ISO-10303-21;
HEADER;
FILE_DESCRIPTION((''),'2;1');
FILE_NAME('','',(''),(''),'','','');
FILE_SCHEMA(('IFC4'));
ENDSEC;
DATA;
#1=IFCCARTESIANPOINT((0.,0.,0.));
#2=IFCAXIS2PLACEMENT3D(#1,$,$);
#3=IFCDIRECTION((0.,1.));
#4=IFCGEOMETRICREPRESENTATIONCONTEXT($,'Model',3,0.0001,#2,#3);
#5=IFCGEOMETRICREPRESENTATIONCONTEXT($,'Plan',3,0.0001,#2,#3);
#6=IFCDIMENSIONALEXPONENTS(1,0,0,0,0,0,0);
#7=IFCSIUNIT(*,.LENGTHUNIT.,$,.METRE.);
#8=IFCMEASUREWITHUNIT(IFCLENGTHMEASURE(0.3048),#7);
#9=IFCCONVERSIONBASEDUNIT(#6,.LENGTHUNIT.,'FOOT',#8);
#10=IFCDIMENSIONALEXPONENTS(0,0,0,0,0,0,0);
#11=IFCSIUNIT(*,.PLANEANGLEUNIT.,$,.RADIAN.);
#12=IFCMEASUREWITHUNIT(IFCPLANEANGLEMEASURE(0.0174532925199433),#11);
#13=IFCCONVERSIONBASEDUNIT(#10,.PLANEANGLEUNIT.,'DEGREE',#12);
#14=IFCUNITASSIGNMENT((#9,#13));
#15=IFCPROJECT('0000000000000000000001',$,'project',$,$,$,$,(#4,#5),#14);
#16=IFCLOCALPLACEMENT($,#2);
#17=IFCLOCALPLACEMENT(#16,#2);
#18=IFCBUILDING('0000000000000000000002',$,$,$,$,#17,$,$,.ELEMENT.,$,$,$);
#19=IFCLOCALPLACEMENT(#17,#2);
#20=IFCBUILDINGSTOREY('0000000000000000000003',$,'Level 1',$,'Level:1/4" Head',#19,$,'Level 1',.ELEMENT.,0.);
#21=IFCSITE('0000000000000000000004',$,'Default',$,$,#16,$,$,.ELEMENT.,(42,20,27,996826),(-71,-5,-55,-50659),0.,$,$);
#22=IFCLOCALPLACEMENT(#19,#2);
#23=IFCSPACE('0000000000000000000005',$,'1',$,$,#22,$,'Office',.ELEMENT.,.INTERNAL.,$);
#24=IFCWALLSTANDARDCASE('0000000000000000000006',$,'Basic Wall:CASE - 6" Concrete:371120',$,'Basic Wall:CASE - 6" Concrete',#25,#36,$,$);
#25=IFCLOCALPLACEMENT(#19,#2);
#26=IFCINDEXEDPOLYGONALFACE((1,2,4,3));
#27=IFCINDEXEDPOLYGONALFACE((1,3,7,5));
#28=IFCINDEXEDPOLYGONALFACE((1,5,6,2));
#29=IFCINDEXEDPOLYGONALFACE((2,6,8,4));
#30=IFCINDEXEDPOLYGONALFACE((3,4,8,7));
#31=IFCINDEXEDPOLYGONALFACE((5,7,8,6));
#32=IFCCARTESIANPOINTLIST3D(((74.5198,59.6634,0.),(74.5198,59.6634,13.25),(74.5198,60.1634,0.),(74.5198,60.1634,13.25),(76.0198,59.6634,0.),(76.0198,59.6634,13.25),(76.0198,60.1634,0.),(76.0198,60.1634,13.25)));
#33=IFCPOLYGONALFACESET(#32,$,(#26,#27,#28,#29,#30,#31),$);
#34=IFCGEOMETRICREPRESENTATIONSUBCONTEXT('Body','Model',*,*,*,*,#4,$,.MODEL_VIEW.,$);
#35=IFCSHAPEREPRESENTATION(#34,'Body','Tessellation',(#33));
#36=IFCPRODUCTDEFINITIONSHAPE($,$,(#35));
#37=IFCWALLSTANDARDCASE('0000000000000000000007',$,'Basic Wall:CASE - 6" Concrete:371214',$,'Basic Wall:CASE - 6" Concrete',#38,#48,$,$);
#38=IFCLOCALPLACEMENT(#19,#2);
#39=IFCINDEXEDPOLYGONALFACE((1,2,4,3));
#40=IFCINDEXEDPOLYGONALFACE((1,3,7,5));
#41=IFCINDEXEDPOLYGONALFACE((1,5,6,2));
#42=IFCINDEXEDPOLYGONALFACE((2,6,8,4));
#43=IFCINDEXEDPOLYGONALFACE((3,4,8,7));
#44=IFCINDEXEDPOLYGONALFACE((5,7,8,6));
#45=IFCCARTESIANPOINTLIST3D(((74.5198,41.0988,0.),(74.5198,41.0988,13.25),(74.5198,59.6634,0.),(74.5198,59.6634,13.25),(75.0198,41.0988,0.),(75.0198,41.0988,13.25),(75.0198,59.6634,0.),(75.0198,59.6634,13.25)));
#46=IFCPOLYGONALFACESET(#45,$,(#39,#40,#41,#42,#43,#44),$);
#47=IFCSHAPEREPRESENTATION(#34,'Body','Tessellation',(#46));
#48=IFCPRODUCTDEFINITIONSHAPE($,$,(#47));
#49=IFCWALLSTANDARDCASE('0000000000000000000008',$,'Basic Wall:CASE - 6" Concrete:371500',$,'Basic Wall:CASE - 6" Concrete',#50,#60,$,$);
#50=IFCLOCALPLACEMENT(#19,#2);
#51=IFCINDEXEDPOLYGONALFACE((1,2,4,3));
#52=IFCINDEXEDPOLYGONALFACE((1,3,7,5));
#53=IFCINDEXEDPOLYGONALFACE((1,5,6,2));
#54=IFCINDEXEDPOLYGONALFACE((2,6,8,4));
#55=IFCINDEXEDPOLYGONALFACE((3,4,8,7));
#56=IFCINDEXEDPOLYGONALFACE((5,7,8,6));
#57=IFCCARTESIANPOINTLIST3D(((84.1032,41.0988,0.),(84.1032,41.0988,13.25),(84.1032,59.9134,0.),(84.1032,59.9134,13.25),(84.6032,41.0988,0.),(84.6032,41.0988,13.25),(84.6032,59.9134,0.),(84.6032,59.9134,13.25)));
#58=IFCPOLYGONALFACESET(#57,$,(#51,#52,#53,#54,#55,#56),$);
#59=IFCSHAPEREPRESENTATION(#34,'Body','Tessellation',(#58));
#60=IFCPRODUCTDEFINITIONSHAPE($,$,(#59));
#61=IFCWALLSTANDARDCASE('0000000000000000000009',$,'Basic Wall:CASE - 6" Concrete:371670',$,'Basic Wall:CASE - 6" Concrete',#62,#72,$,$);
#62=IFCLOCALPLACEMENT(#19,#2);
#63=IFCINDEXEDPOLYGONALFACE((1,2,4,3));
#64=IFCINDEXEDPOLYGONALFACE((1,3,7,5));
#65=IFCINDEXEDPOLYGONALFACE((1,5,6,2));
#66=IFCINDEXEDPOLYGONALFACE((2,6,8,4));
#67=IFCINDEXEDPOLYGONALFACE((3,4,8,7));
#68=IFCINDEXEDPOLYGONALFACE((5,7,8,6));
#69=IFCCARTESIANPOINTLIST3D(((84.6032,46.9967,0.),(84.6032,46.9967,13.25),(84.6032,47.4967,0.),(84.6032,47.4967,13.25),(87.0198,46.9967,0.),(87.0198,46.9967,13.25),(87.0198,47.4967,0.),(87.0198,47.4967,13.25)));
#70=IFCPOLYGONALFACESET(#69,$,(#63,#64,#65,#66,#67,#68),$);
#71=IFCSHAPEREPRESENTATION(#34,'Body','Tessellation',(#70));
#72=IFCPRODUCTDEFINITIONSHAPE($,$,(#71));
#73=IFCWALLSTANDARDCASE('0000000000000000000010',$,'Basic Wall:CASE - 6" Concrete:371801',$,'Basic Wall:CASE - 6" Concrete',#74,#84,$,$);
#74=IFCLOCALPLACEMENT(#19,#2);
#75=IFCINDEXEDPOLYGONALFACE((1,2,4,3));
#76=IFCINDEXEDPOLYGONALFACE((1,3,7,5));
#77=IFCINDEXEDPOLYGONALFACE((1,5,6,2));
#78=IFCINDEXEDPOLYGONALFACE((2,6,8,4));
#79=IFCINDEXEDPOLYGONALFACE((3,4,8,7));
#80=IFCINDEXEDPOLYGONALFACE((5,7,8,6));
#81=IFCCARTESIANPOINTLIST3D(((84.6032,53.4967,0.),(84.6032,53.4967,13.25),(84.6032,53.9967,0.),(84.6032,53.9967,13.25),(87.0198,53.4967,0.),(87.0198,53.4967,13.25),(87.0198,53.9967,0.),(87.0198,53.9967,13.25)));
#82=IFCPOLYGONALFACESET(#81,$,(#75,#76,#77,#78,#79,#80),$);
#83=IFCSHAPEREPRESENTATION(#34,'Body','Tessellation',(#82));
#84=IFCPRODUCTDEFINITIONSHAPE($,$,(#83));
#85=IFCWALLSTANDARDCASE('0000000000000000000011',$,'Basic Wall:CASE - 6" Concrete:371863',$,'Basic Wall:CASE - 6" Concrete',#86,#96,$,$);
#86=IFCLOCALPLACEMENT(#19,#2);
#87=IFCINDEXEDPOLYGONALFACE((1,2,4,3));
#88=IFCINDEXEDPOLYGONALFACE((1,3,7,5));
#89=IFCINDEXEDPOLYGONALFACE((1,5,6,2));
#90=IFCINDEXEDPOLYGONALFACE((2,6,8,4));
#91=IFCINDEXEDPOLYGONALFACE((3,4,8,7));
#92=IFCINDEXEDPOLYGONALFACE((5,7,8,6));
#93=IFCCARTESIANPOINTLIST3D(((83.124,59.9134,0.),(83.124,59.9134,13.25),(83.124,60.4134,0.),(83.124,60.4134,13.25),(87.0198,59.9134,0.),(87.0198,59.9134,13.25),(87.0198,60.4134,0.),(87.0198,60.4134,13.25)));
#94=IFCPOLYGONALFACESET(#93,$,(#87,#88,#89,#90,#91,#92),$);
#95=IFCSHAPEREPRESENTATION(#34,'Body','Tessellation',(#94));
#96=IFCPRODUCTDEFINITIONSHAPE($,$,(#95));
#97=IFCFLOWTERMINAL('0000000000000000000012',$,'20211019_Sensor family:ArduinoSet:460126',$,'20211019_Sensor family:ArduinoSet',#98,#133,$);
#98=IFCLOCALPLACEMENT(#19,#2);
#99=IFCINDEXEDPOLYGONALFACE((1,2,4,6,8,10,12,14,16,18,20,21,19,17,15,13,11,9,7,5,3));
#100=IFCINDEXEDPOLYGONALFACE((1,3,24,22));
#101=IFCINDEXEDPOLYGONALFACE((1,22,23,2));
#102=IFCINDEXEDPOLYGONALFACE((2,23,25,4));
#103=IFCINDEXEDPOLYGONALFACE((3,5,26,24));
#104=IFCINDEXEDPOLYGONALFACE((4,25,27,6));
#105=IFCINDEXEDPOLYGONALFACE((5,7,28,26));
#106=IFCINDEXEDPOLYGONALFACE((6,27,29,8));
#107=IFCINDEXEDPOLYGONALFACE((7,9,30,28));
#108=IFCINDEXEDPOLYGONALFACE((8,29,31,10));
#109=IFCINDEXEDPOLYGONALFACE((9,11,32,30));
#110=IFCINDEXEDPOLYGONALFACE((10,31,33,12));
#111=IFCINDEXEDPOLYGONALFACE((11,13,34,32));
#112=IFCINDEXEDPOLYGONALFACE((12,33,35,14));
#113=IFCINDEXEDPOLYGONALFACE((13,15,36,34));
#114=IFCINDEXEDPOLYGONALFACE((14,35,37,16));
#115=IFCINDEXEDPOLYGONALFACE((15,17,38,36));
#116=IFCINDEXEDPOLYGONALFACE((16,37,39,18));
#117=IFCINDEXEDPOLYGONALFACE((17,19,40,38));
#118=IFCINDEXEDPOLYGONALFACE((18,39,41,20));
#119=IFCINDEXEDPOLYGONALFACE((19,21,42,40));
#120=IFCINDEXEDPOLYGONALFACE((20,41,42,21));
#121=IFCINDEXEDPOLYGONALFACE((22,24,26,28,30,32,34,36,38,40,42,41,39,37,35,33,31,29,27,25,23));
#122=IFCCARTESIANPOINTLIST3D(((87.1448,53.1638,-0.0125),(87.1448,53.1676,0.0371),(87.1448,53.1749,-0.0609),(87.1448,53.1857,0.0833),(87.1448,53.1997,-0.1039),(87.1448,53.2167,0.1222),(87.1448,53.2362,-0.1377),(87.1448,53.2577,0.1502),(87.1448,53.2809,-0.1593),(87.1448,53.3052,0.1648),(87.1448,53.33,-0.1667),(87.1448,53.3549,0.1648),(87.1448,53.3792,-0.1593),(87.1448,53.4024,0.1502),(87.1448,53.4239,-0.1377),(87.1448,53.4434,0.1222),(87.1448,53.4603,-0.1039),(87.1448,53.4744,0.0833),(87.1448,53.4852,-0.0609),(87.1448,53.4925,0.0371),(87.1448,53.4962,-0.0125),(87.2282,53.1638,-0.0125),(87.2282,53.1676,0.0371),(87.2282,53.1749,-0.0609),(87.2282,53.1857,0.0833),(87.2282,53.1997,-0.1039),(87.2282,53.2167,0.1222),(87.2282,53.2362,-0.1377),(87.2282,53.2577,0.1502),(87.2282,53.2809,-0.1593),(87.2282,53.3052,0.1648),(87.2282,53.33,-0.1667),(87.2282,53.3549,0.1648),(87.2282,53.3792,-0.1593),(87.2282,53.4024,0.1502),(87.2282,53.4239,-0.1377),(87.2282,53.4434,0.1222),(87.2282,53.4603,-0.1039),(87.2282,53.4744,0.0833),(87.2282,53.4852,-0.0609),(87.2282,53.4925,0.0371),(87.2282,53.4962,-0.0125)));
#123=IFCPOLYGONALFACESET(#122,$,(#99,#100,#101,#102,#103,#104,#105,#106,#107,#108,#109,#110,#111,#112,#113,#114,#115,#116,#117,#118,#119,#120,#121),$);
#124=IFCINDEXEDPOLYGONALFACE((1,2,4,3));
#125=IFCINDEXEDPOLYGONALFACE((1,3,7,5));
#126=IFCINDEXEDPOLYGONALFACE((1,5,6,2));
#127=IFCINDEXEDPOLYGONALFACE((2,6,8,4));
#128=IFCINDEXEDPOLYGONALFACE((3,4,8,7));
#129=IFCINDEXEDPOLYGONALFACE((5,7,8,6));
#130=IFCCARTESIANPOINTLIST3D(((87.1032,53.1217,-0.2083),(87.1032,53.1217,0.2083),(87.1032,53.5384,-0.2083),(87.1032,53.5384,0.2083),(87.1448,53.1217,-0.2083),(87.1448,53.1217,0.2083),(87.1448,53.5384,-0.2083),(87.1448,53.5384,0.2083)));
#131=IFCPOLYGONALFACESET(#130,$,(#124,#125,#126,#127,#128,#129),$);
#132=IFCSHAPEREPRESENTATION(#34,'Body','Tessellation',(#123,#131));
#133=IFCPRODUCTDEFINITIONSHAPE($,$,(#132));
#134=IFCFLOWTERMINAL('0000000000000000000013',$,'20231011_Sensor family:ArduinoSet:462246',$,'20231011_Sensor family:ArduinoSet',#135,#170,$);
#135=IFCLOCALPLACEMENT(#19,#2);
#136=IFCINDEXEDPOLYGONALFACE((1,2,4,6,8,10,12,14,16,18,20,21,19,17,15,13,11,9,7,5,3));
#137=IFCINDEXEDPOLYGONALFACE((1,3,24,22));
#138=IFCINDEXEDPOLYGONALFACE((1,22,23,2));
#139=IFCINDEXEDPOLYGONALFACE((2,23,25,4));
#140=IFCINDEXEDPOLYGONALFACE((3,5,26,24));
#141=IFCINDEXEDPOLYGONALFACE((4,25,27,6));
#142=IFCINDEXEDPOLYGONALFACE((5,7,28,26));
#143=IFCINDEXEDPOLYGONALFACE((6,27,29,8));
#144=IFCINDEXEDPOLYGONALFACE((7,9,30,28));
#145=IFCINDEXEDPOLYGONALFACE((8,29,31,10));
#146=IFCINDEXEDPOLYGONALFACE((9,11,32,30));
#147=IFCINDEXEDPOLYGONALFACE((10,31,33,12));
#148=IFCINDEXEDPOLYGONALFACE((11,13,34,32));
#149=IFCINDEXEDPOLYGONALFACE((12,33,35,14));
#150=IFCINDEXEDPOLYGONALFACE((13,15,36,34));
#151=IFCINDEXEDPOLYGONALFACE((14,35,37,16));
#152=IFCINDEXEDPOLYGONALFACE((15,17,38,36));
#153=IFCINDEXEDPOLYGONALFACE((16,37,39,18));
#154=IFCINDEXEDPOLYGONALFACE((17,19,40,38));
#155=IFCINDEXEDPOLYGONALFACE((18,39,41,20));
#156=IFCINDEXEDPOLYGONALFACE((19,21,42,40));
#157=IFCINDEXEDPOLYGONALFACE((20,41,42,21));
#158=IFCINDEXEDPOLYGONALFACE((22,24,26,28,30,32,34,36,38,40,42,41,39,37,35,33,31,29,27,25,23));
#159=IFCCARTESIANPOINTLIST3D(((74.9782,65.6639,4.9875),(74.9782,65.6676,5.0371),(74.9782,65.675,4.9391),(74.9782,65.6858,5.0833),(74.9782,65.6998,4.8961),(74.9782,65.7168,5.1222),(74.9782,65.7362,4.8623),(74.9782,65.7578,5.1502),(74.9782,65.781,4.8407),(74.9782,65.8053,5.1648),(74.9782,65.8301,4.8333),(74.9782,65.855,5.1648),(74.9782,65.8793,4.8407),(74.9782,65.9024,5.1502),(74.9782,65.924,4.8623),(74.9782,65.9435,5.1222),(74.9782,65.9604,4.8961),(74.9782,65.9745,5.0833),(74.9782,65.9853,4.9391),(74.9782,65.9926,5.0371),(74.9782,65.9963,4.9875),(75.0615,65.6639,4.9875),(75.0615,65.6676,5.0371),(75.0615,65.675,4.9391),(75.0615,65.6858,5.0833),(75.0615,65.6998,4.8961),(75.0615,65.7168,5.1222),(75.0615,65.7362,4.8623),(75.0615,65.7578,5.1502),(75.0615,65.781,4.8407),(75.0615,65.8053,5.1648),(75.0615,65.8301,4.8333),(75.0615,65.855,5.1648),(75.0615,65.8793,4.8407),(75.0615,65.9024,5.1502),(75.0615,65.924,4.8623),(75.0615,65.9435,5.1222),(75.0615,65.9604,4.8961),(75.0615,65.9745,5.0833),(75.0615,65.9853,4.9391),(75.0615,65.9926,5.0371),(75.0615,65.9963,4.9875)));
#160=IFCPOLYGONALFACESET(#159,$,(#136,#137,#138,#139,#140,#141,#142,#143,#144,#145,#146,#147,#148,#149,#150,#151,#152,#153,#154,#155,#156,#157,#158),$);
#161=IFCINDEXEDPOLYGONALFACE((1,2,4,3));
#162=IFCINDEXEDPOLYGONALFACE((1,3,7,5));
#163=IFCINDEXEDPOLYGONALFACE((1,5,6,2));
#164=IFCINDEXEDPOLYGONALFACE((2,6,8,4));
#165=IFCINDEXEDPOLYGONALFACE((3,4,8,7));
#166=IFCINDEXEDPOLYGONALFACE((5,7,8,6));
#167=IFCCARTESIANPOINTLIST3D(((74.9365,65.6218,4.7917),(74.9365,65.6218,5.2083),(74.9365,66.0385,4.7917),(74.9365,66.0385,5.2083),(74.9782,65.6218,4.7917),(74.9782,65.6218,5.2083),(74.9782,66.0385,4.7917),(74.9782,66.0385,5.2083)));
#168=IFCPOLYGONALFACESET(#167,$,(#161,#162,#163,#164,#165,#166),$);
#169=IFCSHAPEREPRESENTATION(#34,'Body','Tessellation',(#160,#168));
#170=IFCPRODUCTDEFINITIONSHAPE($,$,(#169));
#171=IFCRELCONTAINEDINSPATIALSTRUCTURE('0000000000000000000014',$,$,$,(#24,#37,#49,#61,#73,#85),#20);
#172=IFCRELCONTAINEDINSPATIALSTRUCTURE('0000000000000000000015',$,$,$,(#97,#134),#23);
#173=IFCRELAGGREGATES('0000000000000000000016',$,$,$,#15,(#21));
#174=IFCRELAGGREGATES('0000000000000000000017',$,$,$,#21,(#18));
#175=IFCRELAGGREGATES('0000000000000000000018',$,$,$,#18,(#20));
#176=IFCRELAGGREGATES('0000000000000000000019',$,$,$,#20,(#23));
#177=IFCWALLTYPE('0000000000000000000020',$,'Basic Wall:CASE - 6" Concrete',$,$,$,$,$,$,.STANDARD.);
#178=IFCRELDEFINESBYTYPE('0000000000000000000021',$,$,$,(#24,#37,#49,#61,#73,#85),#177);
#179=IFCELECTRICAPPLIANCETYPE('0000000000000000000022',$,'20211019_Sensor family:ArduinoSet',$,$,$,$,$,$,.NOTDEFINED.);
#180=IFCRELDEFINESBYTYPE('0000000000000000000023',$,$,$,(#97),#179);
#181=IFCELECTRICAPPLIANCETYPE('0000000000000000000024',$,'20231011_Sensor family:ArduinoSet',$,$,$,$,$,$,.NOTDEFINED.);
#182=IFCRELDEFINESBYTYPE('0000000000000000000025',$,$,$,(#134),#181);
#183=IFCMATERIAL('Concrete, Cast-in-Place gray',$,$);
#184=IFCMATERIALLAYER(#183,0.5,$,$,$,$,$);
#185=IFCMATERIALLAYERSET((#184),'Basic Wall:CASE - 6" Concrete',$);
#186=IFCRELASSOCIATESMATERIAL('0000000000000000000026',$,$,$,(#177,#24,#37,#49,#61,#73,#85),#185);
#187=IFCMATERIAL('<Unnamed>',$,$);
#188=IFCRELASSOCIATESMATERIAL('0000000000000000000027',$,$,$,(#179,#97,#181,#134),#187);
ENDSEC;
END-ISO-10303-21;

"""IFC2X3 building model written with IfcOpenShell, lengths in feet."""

from ifc_helpers import new_model, entity, si_unit, converted_unit, direction, frame, frame_2d, origin, origin_2d_with_axis, place, context, subcontext, project, spatial, rectangle, circle, extrude, source, transform, mapped, material, layer, layer_set, layer_usage, type_object, type_shapes, element, save


model = new_model("IFC2X3")

# Units and contexts
model_context = context("Model", 3, precision=0.0001, world=origin(), true_north=direction((0.0, 1.0)))
plan_context = context("Plan", 3, precision=0.0001, world=origin(), true_north=direction((0.0, 1.0)))
body_context = subcontext(model_context, "Body", "Model", "MODEL_VIEW")
ifc_project = project(units=[converted_unit("LENGTHUNIT", "FOOT", entity("IfcLengthMeasure", 0.3048), si_unit("LENGTHUNIT", "METRE"), dimensions=[1, 0, 0, 0, 0, 0, 0]), converted_unit("PLANEANGLEUNIT", "DEGREE", entity("IfcPlaneAngleMeasure", 0.0174532925199433), si_unit("PLANEANGLEUNIT", "RADIAN"), dimensions=[0, 0, 0, 0, 0, 0, 0])], contexts=[model_context, plan_context])

# Site, building, storey
site_placement = place(None, origin())
site = spatial("IfcSite", under=ifc_project, at=site_placement, Name="Default", CompositionType="ELEMENT", RefLatitude=(42, 20, 27, 996826), RefLongitude=(-71, -5, -55, -50659), RefElevation=0.0)
building_placement = place(site_placement, origin())
building = spatial("IfcBuilding", under=site, at=building_placement, CompositionType="ELEMENT")
storey_placement = place(building_placement, origin())
storey = spatial("IfcBuildingStorey", under=building, at=storey_placement, Name="Level 1", ObjectType="Level:1/4\" Head", LongName="Level 1", CompositionType="ELEMENT", Elevation=0.0)

# Shared definitions
ifc_material_1 = material(Name="<Unnamed>")

# Shared definitions
ifc_material_2 = material(Name="Concrete, Cast-in-Place gray")
ifc_layer = layer(ifc_material_2, 0.5)
ifc_layer_set = layer_set([ifc_layer], Name="Basic Wall:CASE - 6\" Concrete")
wall_type = type_object("IfcWallType", Name="Basic Wall:CASE - 6\" Concrete", PredefinedType="STANDARD", material=ifc_layer_set)

# Walls
ifc_layer_usage_1 = layer_usage(ifc_layer_set, "AXIS2", "NEGATIVE", 0.25)
wall_1_placement = place(storey_placement, frame((76.0198, 59.9134, 0.0), z_axis=(0.0, 0.0, 1.0), x_axis=(-1.0, 0.0, 0.0)))
element("IfcWallStandardCase", 1, at=wall_1_placement, inside=storey, type_object=wall_type, material=ifc_layer_usage_1, Name="Basic Wall:CASE - 6\" Concrete:371120", ObjectType="Basic Wall:CASE - 6\" Concrete", context=body_context, shape_type="SweptSolid", body=[
    extrude(rectangle(XDim=1.5, YDim=0.5, at=frame_2d((0.75, 0.0), x_axis=(-1.0, 0.0))), origin(), (0.0, 0.0, 1.0), 13.25),
])
ifc_layer_usage_2 = layer_usage(ifc_layer_set, "AXIS2", "NEGATIVE", 0.25)
wall_2_placement = place(storey_placement, frame((74.7698, 59.6634, 0.0), z_axis=(0.0, 0.0, 1.0), x_axis=(0.0, -1.0, 0.0)))
element("IfcWallStandardCase", 2, at=wall_2_placement, inside=storey, type_object=wall_type, material=ifc_layer_usage_2, Name="Basic Wall:CASE - 6\" Concrete:371214", ObjectType="Basic Wall:CASE - 6\" Concrete", context=body_context, shape_type="SweptSolid", body=[
    extrude(rectangle(XDim=18.5645, YDim=0.5, at=frame_2d((9.2823, 0.0), x_axis=(-1.0, 0.0))), origin(), (0.0, 0.0, 1.0), 13.25),
])
ifc_layer_usage_3 = layer_usage(ifc_layer_set, "AXIS2", "NEGATIVE", 0.25)
wall_3_placement = place(storey_placement, frame((84.3532, 59.9134, 0.0), z_axis=(0.0, 0.0, 1.0), x_axis=(0.0, -1.0, 0.0)))
element("IfcWallStandardCase", 3, at=wall_3_placement, inside=storey, type_object=wall_type, material=ifc_layer_usage_3, Name="Basic Wall:CASE - 6\" Concrete:371500", ObjectType="Basic Wall:CASE - 6\" Concrete", context=body_context, shape_type="SweptSolid", body=[
    extrude(rectangle(XDim=18.8145, YDim=0.5, at=frame_2d((9.4073, 0.0), x_axis=(-1.0, 0.0))), origin(), (0.0, 0.0, 1.0), 13.25),
])
ifc_layer_usage_4 = layer_usage(ifc_layer_set, "AXIS2", "NEGATIVE", 0.25)
wall_4_placement = place(storey_placement, frame((87.0198, 47.2467, 0.0), z_axis=(0.0, 0.0, 1.0), x_axis=(-1.0, 0.0, 0.0)))
element("IfcWallStandardCase", 4, at=wall_4_placement, inside=storey, type_object=wall_type, material=ifc_layer_usage_4, Name="Basic Wall:CASE - 6\" Concrete:371670", ObjectType="Basic Wall:CASE - 6\" Concrete", context=body_context, shape_type="SweptSolid", body=[
    extrude(rectangle(XDim=2.4167, YDim=0.5, at=frame_2d((1.2083, 0.0), x_axis=(-1.0, 0.0))), origin(), (0.0, 0.0, 1.0), 13.25),
])
ifc_layer_usage_5 = layer_usage(ifc_layer_set, "AXIS2", "NEGATIVE", 0.25)
wall_5_placement = place(storey_placement, frame((87.0198, 53.7467, 0.0), z_axis=(0.0, 0.0, 1.0), x_axis=(-1.0, 0.0, 0.0)))
element("IfcWallStandardCase", 5, at=wall_5_placement, inside=storey, type_object=wall_type, material=ifc_layer_usage_5, Name="Basic Wall:CASE - 6\" Concrete:371801", ObjectType="Basic Wall:CASE - 6\" Concrete", context=body_context, shape_type="SweptSolid", body=[
    extrude(rectangle(XDim=2.4167, YDim=0.5, at=frame_2d((1.2083, 0.0), x_axis=(-1.0, 0.0))), origin(), (0.0, 0.0, 1.0), 13.25),
])
ifc_layer_usage_6 = layer_usage(ifc_layer_set, "AXIS2", "NEGATIVE", 0.25)
wall_6_placement = place(storey_placement, frame((87.0198, 60.1634, 0.0), z_axis=(0.0, 0.0, 1.0), x_axis=(-1.0, 0.0, 0.0)))
element("IfcWallStandardCase", 6, at=wall_6_placement, inside=storey, type_object=wall_type, material=ifc_layer_usage_6, Name="Basic Wall:CASE - 6\" Concrete:371863", ObjectType="Basic Wall:CASE - 6\" Concrete", context=body_context, shape_type="SweptSolid", body=[
    extrude(rectangle(XDim=3.8958, YDim=0.5, at=frame_2d((1.9479, 0.0), x_axis=(-1.0, 0.0))), origin(), (0.0, 0.0, 1.0), 13.25),
])

# Shared definitions
space_1_placement = place(storey_placement, origin())
space_1 = spatial("IfcSpace", under=storey, at=space_1_placement, Name="1", LongName="Office", CompositionType="ELEMENT", InteriorOrExteriorSpace="INTERNAL")

# Flow terminals
electric_appliance_type_1 = type_object("IfcElectricApplianceType", Name="20211019_Sensor family:ArduinoSet", PredefinedType="NOTDEFINED", material=ifc_material_1)
shared_shape_1 = source(origin(), body_context, "Body", "SweptSolid", [
    extrude(circle(Radius=0.1667, at=frame_2d((0.0, 0.0), x_axis=(1.0, 0.0))), frame((0.0417, 0.0, 0.0), z_axis=(1.0, 0.0, 0.0), x_axis=(0.0, 0.0, -1.0)), (0.0, 0.0, 1.0), 0.0833),
    extrude(rectangle(XDim=0.0417, YDim=0.4167, at=origin_2d_with_axis()), frame((0.0208, 0.0, -0.2083), z_axis=(0.0, 0.0, 1.0), x_axis=(-1.0, 0.0, 0.0)), (0.0, 0.0, 1.0), 0.4167),
])
type_shapes(electric_appliance_type_1, [shared_shape_1])
flow_terminal_1_placement = place(space_1_placement, frame((87.1032, 53.33, 0.0)))
element("IfcFlowTerminal", 7, at=flow_terminal_1_placement, inside=space_1, type_object=electric_appliance_type_1, material=ifc_material_1, Name="20211019_Sensor family:ArduinoSet:460126", ObjectType="20211019_Sensor family:ArduinoSet", context=body_context, shape_type="MappedRepresentation", body=[
    mapped(shared_shape_1, transform((0.0, 0.0, 0.0), scale=1.0)),
])
electric_appliance_type_2 = type_object("IfcElectricApplianceType", Name="20231011_Sensor family:ArduinoSet", PredefinedType="NOTDEFINED", material=ifc_material_1)
shared_shape_2 = source(origin(), body_context, "Body", "SweptSolid", [
    extrude(circle(Radius=0.1667, at=frame_2d((0.0, 0.0), x_axis=(1.0, 0.0))), frame((0.0417, 0.0, 0.0), z_axis=(1.0, 0.0, 0.0), x_axis=(0.0, 0.0, -1.0)), (0.0, 0.0, 1.0), 0.0833),
    extrude(rectangle(XDim=0.0417, YDim=0.4167, at=origin_2d_with_axis()), frame((0.0208, 0.0, -0.2083), z_axis=(0.0, 0.0, 1.0), x_axis=(-1.0, 0.0, 0.0)), (0.0, 0.0, 1.0), 0.4167),
])
type_shapes(electric_appliance_type_2, [shared_shape_2])
flow_terminal_2_placement = place(space_1_placement, frame((74.9365, 65.8301, 5.0)))
element("IfcFlowTerminal", 8, at=flow_terminal_2_placement, inside=space_1, type_object=electric_appliance_type_2, material=ifc_material_1, Name="20231011_Sensor family:ArduinoSet:462246", ObjectType="20231011_Sensor family:ArduinoSet", context=body_context, shape_type="MappedRepresentation", body=[
    mapped(shared_shape_2, transform((0.0, 0.0, 0.0), scale=1.0)),
])

save(model, "model.ifc")
